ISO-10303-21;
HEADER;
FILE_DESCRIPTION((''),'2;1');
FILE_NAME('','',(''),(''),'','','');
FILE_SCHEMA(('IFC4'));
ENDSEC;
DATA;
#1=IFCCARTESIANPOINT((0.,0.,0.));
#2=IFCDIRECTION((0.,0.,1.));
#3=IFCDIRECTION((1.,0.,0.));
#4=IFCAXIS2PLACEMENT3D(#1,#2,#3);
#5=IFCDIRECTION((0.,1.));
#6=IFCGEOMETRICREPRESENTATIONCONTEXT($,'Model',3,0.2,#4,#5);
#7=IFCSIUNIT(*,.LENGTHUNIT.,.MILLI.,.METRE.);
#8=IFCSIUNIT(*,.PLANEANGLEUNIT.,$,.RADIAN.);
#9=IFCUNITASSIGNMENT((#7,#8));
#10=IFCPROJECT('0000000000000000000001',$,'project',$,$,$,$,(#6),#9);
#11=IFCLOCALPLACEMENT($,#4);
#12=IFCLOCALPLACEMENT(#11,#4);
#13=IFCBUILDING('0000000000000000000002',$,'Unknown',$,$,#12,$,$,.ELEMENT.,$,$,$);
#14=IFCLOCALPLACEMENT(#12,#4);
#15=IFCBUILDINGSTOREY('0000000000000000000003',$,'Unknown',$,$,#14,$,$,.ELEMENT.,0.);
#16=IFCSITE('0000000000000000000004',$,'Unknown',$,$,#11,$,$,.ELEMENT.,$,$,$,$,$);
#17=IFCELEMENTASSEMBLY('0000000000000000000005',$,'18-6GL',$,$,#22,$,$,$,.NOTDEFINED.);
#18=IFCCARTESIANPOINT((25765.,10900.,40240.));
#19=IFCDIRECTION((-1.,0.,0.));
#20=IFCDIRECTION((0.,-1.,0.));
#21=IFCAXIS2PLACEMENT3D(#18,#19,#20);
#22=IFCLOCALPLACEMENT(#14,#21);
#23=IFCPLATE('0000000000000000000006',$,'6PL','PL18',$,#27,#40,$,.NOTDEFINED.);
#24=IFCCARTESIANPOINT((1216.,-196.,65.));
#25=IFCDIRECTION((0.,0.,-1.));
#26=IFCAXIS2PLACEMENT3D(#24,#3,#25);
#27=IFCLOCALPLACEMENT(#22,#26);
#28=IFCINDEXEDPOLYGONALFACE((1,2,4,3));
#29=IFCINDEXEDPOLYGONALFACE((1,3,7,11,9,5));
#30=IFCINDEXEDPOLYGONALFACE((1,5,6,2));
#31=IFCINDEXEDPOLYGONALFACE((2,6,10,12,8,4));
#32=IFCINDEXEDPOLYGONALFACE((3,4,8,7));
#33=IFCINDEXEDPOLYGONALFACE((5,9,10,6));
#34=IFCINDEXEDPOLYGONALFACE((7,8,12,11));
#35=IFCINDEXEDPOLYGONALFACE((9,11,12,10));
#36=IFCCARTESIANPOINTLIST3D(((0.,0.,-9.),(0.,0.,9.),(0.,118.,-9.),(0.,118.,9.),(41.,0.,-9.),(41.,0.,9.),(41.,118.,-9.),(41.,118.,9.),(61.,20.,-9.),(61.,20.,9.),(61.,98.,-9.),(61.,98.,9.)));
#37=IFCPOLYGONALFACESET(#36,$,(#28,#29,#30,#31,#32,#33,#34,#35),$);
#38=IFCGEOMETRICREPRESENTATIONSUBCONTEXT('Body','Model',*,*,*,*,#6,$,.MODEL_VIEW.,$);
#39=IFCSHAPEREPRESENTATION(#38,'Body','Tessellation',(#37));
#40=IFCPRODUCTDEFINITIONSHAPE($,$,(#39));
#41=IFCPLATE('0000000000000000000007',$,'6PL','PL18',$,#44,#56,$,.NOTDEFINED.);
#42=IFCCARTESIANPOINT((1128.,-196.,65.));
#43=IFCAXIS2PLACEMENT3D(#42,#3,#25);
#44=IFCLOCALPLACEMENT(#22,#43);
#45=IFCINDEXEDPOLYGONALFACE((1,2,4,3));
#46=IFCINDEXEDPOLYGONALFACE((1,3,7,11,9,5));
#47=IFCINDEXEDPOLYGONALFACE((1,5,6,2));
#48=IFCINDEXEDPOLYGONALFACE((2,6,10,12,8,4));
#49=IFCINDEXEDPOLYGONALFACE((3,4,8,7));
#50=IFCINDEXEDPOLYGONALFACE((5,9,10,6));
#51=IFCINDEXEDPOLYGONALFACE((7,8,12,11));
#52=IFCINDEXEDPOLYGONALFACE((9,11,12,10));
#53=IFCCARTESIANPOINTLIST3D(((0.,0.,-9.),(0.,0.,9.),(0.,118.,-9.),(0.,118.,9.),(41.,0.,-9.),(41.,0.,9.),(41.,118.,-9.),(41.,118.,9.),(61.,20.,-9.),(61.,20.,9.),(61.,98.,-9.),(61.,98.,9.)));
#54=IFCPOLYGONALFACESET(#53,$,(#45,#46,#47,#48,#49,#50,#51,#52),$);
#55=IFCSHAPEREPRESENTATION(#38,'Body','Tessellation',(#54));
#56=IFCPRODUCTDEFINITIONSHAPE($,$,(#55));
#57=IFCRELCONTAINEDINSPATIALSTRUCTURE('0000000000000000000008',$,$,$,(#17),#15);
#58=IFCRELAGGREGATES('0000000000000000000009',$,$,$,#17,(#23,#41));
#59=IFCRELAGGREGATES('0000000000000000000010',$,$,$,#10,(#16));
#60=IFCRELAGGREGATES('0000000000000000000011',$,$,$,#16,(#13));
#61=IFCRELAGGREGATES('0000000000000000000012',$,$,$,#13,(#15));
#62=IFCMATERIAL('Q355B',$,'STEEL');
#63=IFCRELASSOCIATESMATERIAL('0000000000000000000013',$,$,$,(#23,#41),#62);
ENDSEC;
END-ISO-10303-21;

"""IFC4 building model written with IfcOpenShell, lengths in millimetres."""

from ifc_helpers import new_model, si_unit, direction, frame, origin_with_axes, place, context, subcontext, project, spatial, line, indexed_curve, outline, extrude, material, element, aggregate, save


model = new_model("IFC4")

# Units and contexts
model_context = context("Model", 3, precision=0.2, world=origin_with_axes(), true_north=direction((0.0, 1.0)))
body_context = subcontext(model_context, "Body", "Model", "MODEL_VIEW")
ifc_project = project(units=[si_unit("LENGTHUNIT", "METRE", prefix="MILLI"), si_unit("PLANEANGLEUNIT", "RADIAN")], contexts=[model_context])

# Site, building, storey
site_placement = place(None, origin_with_axes())
site = spatial("IfcSite", under=ifc_project, at=site_placement, Name="Unknown", CompositionType="ELEMENT")
building_placement = place(site_placement, origin_with_axes())
building = spatial("IfcBuilding", under=site, at=building_placement, Name="Unknown", CompositionType="ELEMENT")
storey_placement = place(building_placement, origin_with_axes())
storey = spatial("IfcBuildingStorey", under=building, at=storey_placement, Name="Unknown", CompositionType="ELEMENT", Elevation=0.0)

# Shared definitions
ifc_material_1 = material(Name="Q355B", Category="STEEL")

# Element assembly, plates
assembly_1_placement = place(storey_placement, frame((25765.0, 10900.0, 40240.0), z_axis=(-1.0, 0.0, 0.0), x_axis=(0.0, -1.0, 0.0)))
assembly_1 = element("IfcElementAssembly", 1, at=assembly_1_placement, inside=storey, Name="18-6GL", PredefinedType="NOTDEFINED")
plate_1_placement = place(assembly_1_placement, frame((1216.0, -196.0, 65.0), z_axis=(1.0, 0.0, 0.0), x_axis=(0.0, 0.0, -1.0)))
plate_1 = element("IfcPlate", 2, at=plate_1_placement, material=ifc_material_1, Name="6PL", Description="PL18", PredefinedType="NOTDEFINED", context=body_context, shape_type="SolidModel", body=[
    extrude(outline(indexed_curve([(0.0, 0.0), (41.0, 0.0), (61.0, 20.0), (61.0, 98.0), (41.0, 118.0), (0.0, 118.0)], segments=[line(1, 2, 3, 4, 5, 6, 1)])), frame((0.0, 0.0, 9.0), z_axis=(0.0, 0.0, 1.0), x_axis=(1.0, 0.0, 0.0)), (0.0, 0.0, -1.0), 18.0),
])
plate_2_placement = place(assembly_1_placement, frame((1128.0, -196.0, 65.0), z_axis=(1.0, 0.0, 0.0), x_axis=(0.0, 0.0, -1.0)))
plate_2 = element("IfcPlate", 3, at=plate_2_placement, material=ifc_material_1, Name="6PL", Description="PL18", PredefinedType="NOTDEFINED", context=body_context, shape_type="SolidModel", body=[
    extrude(outline(indexed_curve([(0.0, 0.0), (41.0, 0.0), (61.0, 20.0), (61.0, 98.0), (41.0, 118.0), (0.0, 118.0)], segments=[line(1, 2, 3, 4, 5, 6, 1)])), frame((0.0, 0.0, 9.0), z_axis=(0.0, 0.0, 1.0), x_axis=(1.0, 0.0, 0.0)), (0.0, 0.0, -1.0), 18.0),
])
aggregate(assembly_1, [plate_1, plate_2])

save(model, "model.ifc")
